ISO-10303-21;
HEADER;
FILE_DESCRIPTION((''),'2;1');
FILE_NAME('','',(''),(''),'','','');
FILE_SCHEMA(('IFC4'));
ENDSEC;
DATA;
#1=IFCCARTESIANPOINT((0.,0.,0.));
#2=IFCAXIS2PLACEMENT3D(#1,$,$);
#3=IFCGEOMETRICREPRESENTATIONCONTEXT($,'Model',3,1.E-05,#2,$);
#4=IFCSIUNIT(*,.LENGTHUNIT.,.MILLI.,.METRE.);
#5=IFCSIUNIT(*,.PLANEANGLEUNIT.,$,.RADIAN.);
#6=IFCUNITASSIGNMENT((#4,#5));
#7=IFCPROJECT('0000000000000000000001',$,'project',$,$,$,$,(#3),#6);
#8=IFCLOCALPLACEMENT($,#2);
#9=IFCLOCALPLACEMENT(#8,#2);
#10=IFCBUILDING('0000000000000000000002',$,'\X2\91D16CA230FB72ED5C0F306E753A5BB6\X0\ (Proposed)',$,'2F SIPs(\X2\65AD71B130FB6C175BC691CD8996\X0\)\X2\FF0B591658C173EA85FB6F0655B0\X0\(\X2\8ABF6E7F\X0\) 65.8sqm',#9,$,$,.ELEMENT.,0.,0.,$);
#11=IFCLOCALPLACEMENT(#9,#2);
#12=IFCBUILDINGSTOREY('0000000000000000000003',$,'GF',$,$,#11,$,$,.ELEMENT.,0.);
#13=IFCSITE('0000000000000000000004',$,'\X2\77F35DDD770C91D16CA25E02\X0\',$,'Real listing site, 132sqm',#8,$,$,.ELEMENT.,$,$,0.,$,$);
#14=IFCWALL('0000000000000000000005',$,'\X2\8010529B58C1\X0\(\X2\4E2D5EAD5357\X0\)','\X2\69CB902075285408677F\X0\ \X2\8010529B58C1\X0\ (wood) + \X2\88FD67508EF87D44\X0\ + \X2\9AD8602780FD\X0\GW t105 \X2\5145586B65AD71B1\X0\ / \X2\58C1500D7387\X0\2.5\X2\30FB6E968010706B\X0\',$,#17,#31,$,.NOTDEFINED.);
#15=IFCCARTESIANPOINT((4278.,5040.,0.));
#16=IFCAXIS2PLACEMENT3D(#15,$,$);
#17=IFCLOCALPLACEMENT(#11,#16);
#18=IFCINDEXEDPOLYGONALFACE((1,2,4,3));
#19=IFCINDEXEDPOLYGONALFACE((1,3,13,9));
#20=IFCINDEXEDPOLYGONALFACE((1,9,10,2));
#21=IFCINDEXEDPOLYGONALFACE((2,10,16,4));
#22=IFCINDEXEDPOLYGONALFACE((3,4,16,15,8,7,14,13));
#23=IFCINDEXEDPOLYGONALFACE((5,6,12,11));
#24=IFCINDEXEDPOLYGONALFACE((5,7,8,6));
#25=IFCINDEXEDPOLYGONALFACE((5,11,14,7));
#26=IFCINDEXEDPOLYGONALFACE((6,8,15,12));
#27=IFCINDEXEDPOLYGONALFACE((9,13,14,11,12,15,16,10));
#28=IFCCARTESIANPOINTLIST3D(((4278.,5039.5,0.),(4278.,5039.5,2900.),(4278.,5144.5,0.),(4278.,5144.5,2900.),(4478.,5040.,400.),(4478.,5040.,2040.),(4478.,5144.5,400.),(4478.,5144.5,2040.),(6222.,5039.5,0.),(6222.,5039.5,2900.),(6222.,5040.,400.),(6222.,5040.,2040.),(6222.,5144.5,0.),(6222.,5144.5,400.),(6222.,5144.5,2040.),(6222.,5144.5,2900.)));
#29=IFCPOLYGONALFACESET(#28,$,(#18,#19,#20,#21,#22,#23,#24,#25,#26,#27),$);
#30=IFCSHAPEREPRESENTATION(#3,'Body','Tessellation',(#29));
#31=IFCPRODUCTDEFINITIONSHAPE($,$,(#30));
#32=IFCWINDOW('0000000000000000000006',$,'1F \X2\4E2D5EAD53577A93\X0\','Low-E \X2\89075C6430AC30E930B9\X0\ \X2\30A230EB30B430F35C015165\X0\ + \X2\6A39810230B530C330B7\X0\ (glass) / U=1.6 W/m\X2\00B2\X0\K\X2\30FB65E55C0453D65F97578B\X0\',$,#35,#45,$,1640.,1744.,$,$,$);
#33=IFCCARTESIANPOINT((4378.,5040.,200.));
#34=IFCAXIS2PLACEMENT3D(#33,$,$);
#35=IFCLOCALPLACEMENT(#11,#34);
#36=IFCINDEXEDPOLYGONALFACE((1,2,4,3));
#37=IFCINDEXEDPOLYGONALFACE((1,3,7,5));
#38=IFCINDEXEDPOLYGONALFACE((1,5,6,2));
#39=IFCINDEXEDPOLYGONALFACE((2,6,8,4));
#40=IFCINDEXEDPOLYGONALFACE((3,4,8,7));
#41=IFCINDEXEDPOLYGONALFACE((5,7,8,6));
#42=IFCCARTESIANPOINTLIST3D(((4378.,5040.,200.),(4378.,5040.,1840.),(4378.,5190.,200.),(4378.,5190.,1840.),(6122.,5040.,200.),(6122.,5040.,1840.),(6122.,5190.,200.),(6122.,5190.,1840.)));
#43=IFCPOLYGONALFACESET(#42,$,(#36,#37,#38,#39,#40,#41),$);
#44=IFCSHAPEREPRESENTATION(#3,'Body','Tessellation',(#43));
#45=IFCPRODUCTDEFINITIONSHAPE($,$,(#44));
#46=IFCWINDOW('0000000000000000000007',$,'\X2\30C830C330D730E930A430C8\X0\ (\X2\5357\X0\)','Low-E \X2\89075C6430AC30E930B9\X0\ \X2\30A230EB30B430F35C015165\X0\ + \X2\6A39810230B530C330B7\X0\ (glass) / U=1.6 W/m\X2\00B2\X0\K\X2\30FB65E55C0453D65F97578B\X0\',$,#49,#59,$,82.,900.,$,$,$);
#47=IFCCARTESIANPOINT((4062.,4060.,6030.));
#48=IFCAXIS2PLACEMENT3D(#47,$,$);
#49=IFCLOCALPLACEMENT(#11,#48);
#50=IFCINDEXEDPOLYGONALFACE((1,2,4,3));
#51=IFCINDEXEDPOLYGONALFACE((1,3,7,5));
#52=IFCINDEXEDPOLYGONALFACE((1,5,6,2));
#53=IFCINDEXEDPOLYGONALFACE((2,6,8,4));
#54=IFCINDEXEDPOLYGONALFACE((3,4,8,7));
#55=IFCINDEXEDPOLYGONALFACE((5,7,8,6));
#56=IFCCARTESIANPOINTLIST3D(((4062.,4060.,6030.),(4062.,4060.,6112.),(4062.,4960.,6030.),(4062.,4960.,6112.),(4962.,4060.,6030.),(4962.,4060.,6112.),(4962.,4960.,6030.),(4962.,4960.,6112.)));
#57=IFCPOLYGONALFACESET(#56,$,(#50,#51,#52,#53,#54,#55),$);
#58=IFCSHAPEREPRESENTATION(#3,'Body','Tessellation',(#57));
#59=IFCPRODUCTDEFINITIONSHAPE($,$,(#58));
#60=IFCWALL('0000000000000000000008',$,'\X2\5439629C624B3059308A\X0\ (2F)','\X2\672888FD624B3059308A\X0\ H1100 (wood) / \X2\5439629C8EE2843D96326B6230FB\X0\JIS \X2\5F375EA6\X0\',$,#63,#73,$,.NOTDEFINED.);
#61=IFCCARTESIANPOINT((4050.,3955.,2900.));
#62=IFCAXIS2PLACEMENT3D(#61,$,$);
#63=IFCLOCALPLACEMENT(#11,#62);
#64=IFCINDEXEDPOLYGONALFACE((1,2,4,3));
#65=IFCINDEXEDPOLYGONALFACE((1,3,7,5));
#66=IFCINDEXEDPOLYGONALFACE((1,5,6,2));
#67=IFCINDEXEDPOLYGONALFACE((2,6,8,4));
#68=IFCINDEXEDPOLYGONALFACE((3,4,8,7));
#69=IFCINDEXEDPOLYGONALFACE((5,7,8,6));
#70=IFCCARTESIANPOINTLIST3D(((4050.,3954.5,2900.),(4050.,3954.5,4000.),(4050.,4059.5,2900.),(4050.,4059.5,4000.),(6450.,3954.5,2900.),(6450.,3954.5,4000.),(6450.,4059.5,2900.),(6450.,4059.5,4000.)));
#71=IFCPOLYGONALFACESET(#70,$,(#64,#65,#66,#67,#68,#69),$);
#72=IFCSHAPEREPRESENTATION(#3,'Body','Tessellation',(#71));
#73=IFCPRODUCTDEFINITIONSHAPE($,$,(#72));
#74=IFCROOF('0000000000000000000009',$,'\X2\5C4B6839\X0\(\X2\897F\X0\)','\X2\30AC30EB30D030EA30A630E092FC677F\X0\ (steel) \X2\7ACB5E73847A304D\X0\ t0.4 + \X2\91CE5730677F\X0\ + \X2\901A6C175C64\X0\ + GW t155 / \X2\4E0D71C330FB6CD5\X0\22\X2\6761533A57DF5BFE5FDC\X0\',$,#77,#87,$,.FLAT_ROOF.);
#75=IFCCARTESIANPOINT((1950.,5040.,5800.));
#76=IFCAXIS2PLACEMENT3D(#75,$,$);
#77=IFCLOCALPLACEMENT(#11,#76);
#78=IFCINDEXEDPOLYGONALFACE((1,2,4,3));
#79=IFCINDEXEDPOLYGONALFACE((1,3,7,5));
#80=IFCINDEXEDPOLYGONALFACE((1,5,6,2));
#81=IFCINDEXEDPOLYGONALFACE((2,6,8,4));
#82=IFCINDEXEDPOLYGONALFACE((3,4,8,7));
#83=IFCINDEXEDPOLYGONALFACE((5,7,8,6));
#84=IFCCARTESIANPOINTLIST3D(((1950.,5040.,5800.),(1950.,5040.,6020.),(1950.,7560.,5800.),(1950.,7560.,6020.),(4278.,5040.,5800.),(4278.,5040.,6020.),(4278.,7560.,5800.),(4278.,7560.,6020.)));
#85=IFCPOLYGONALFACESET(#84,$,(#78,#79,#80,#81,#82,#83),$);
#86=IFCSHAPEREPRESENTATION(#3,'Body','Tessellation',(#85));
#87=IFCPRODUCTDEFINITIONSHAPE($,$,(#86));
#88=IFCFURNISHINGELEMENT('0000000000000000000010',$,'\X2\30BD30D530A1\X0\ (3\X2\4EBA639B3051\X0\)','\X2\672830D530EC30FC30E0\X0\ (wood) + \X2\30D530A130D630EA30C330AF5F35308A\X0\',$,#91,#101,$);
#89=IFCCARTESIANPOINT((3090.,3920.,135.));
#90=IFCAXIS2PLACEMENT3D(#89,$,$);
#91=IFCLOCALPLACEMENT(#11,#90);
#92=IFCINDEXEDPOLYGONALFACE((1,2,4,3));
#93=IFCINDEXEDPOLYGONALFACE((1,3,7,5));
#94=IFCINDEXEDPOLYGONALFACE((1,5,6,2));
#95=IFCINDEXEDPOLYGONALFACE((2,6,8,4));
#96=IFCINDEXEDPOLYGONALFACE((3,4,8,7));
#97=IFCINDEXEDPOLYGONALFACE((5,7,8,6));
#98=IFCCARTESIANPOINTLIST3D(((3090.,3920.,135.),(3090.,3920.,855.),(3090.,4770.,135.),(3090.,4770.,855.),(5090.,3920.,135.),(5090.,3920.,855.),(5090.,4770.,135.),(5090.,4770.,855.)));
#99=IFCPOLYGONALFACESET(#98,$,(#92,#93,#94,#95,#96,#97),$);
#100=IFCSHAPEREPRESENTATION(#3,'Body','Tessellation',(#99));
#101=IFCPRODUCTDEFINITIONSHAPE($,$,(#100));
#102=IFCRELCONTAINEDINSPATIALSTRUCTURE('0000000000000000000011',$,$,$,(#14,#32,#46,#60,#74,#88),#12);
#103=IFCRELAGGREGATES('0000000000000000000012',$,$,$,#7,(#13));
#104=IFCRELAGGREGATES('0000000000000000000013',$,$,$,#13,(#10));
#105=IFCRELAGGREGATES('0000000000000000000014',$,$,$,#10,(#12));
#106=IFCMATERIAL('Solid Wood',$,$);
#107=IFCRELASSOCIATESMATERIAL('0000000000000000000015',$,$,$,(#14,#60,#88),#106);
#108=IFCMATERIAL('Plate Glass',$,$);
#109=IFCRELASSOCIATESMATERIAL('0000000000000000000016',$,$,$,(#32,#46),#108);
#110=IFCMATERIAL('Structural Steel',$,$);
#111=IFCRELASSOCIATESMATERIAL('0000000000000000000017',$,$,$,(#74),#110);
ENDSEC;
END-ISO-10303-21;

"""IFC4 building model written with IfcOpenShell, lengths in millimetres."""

from ifc_helpers import new_model, si_unit, frame, frame_2d, origin, place, context, project, spatial, rectangle, extrude, material, element, fill, save


model = new_model("IFC4")

# Units and contexts
model_context = context("Model", 3, precision=1e-05, world=origin())
ifc_project = project(units=[si_unit("LENGTHUNIT", "METRE", prefix="MILLI"), si_unit("PLANEANGLEUNIT", "RADIAN")], contexts=[model_context])

# Site, building, storey
site_placement = place(None, origin())
site = spatial("IfcSite", under=ifc_project, at=site_placement, Name="石川県金沢市", ObjectType="Real listing site, 132sqm", CompositionType="ELEMENT", RefElevation=0.0)
building_placement = place(site_placement, origin())
building = spatial("IfcBuilding", under=site, at=building_placement, Name="金沢・狭小の町家 (Proposed)", ObjectType="2F SIPs(断熱・気密重視)＋外壁珪藻漆喰(調湿) 65.8sqm", CompositionType="ELEMENT", ElevationOfRefHeight=0.0, ElevationOfTerrain=0.0)
storey_placement = place(building_placement, origin())
storey = spatial("IfcBuildingStorey", under=building, at=storey_placement, Name="GF", CompositionType="ELEMENT", Elevation=0.0)

# Shared definitions
ifc_material_1 = material(Name="Solid Wood")

# Wall, opening, window
wall_1_placement = place(storey_placement, frame((4278.0, 5040.0, 0.0)))
wall_1 = element("IfcWall", 1, at=wall_1_placement, inside=storey, material=ifc_material_1, Name="耐力壁(中庭南)", Description="構造用合板 耐力壁 (wood) + 製材軸組 + 高性能GW t105 充填断熱 / 壁倍率2.5・準耐火", PredefinedType="NOTDEFINED", context=model_context, shape_type="SweptSolid", body=[
    extrude(rectangle(XDim=1944.0, YDim=105.0, at=frame_2d((972.0, 52.0))), frame((4278.0, 5040.0, 0.0)), (0.0, 0.0, 1.0), 2900.0),
])
opening_placement = place(storey_placement, frame((4378.0, 5040.0, 200.0)))
opening = element("IfcOpeningElement", 2, at=opening_placement, cuts=wall_1, PredefinedType="NOTDEFINED", context=model_context, shape_type="SweptSolid", body=[
    extrude(rectangle(XDim=1744.0, YDim=150.0, at=frame_2d((872.0, 75.0))), frame((4378.0, 5040.0, 200.0)), (0.0, 0.0, 1.0), 1640.0),
])
ifc_material_2 = material(Name="Plate Glass")
window_1_placement = place(storey_placement, frame((4378.0, 5040.0, 200.0)))
window_1 = element("IfcWindow", 3, at=window_1_placement, inside=storey, material=ifc_material_2, Name="1F 中庭南窓", Description="Low-E 複層ガラス アルゴン封入 + 樹脂サッシ (glass) / U=1.6 W/m²K・日射取得型", OverallHeight=1640.0, OverallWidth=1744.0, context=model_context, shape_type="SweptSolid", body=[
    extrude(rectangle(XDim=1744.0, YDim=150.0, at=frame_2d((872.0, 75.0))), frame((4378.0, 5040.0, 200.0)), (0.0, 0.0, 1.0), 1640.0),
])
fill(opening, window_1)

# Window
window_2_placement = place(storey_placement, frame((4062.0, 4060.0, 6030.0)))
element("IfcWindow", 4, at=window_2_placement, inside=storey, material=ifc_material_2, Name="トップライト (南)", Description="Low-E 複層ガラス アルゴン封入 + 樹脂サッシ (glass) / U=1.6 W/m²K・日射取得型", OverallHeight=82.0, OverallWidth=900.0, context=model_context, shape_type="SweptSolid", body=[
    extrude(rectangle(XDim=900.0, YDim=900.0, at=frame_2d((450.0, 450.0))), frame((4062.0, 4060.0, 6030.0)), (0.0, 0.0, 1.0), 82.0),
])

# Wall
wall_2_placement = place(storey_placement, frame((4050.0, 3955.0, 2900.0)))
element("IfcWall", 5, at=wall_2_placement, inside=storey, material=ifc_material_1, Name="吹抜手すり (2F)", Description="木製手すり H1100 (wood) / 吹抜転落防止・JIS 強度", PredefinedType="NOTDEFINED", context=model_context, shape_type="SweptSolid", body=[
    extrude(rectangle(XDim=2400.0, YDim=105.0, at=frame_2d((1200.0, 52.0))), frame((4050.0, 3955.0, 2900.0)), (0.0, 0.0, 1.0), 1100.0),
])

# Roof
ifc_material_3 = material(Name="Structural Steel")
for number, where, name in (
    (6, (1950.0, 5040.0, 5800.0), "屋根(西)"),
):
    element("IfcRoof", number, at=place(storey_placement, frame(where)), inside=storey, material=ifc_material_3, Name=name, Description="ガルバリウム鋼板 (steel) 立平葺き t0.4 + 野地板 + 通気層 + GW t155 / 不燃・法22条区域対応", PredefinedType="FLAT_ROOF", context=model_context, shape_type="SweptSolid", body=[
        extrude(rectangle(XDim=2328.0, YDim=2520.0, at=frame_2d((1164.0, 1260.0))), frame((1950.0, 5040.0, 5800.0)), (0.0, 0.0, 1.0), 220.0),
    ])

# Furnishing element
furnishing_placement = place(storey_placement, frame((3090.0, 3920.0, 135.0)))
element("IfcFurnishingElement", 7, at=furnishing_placement, inside=storey, material=ifc_material_1, Name="ソファ (3人掛け)", Description="木フレーム (wood) + ファブリック張り", context=model_context, shape_type="SweptSolid", body=[
    extrude(rectangle(XDim=2000.0, YDim=850.0, at=frame_2d((1000.0, 425.0))), frame((3090.0, 3920.0, 135.0)), (0.0, 0.0, 1.0), 720.0),
])

save(model, "model.ifc")
